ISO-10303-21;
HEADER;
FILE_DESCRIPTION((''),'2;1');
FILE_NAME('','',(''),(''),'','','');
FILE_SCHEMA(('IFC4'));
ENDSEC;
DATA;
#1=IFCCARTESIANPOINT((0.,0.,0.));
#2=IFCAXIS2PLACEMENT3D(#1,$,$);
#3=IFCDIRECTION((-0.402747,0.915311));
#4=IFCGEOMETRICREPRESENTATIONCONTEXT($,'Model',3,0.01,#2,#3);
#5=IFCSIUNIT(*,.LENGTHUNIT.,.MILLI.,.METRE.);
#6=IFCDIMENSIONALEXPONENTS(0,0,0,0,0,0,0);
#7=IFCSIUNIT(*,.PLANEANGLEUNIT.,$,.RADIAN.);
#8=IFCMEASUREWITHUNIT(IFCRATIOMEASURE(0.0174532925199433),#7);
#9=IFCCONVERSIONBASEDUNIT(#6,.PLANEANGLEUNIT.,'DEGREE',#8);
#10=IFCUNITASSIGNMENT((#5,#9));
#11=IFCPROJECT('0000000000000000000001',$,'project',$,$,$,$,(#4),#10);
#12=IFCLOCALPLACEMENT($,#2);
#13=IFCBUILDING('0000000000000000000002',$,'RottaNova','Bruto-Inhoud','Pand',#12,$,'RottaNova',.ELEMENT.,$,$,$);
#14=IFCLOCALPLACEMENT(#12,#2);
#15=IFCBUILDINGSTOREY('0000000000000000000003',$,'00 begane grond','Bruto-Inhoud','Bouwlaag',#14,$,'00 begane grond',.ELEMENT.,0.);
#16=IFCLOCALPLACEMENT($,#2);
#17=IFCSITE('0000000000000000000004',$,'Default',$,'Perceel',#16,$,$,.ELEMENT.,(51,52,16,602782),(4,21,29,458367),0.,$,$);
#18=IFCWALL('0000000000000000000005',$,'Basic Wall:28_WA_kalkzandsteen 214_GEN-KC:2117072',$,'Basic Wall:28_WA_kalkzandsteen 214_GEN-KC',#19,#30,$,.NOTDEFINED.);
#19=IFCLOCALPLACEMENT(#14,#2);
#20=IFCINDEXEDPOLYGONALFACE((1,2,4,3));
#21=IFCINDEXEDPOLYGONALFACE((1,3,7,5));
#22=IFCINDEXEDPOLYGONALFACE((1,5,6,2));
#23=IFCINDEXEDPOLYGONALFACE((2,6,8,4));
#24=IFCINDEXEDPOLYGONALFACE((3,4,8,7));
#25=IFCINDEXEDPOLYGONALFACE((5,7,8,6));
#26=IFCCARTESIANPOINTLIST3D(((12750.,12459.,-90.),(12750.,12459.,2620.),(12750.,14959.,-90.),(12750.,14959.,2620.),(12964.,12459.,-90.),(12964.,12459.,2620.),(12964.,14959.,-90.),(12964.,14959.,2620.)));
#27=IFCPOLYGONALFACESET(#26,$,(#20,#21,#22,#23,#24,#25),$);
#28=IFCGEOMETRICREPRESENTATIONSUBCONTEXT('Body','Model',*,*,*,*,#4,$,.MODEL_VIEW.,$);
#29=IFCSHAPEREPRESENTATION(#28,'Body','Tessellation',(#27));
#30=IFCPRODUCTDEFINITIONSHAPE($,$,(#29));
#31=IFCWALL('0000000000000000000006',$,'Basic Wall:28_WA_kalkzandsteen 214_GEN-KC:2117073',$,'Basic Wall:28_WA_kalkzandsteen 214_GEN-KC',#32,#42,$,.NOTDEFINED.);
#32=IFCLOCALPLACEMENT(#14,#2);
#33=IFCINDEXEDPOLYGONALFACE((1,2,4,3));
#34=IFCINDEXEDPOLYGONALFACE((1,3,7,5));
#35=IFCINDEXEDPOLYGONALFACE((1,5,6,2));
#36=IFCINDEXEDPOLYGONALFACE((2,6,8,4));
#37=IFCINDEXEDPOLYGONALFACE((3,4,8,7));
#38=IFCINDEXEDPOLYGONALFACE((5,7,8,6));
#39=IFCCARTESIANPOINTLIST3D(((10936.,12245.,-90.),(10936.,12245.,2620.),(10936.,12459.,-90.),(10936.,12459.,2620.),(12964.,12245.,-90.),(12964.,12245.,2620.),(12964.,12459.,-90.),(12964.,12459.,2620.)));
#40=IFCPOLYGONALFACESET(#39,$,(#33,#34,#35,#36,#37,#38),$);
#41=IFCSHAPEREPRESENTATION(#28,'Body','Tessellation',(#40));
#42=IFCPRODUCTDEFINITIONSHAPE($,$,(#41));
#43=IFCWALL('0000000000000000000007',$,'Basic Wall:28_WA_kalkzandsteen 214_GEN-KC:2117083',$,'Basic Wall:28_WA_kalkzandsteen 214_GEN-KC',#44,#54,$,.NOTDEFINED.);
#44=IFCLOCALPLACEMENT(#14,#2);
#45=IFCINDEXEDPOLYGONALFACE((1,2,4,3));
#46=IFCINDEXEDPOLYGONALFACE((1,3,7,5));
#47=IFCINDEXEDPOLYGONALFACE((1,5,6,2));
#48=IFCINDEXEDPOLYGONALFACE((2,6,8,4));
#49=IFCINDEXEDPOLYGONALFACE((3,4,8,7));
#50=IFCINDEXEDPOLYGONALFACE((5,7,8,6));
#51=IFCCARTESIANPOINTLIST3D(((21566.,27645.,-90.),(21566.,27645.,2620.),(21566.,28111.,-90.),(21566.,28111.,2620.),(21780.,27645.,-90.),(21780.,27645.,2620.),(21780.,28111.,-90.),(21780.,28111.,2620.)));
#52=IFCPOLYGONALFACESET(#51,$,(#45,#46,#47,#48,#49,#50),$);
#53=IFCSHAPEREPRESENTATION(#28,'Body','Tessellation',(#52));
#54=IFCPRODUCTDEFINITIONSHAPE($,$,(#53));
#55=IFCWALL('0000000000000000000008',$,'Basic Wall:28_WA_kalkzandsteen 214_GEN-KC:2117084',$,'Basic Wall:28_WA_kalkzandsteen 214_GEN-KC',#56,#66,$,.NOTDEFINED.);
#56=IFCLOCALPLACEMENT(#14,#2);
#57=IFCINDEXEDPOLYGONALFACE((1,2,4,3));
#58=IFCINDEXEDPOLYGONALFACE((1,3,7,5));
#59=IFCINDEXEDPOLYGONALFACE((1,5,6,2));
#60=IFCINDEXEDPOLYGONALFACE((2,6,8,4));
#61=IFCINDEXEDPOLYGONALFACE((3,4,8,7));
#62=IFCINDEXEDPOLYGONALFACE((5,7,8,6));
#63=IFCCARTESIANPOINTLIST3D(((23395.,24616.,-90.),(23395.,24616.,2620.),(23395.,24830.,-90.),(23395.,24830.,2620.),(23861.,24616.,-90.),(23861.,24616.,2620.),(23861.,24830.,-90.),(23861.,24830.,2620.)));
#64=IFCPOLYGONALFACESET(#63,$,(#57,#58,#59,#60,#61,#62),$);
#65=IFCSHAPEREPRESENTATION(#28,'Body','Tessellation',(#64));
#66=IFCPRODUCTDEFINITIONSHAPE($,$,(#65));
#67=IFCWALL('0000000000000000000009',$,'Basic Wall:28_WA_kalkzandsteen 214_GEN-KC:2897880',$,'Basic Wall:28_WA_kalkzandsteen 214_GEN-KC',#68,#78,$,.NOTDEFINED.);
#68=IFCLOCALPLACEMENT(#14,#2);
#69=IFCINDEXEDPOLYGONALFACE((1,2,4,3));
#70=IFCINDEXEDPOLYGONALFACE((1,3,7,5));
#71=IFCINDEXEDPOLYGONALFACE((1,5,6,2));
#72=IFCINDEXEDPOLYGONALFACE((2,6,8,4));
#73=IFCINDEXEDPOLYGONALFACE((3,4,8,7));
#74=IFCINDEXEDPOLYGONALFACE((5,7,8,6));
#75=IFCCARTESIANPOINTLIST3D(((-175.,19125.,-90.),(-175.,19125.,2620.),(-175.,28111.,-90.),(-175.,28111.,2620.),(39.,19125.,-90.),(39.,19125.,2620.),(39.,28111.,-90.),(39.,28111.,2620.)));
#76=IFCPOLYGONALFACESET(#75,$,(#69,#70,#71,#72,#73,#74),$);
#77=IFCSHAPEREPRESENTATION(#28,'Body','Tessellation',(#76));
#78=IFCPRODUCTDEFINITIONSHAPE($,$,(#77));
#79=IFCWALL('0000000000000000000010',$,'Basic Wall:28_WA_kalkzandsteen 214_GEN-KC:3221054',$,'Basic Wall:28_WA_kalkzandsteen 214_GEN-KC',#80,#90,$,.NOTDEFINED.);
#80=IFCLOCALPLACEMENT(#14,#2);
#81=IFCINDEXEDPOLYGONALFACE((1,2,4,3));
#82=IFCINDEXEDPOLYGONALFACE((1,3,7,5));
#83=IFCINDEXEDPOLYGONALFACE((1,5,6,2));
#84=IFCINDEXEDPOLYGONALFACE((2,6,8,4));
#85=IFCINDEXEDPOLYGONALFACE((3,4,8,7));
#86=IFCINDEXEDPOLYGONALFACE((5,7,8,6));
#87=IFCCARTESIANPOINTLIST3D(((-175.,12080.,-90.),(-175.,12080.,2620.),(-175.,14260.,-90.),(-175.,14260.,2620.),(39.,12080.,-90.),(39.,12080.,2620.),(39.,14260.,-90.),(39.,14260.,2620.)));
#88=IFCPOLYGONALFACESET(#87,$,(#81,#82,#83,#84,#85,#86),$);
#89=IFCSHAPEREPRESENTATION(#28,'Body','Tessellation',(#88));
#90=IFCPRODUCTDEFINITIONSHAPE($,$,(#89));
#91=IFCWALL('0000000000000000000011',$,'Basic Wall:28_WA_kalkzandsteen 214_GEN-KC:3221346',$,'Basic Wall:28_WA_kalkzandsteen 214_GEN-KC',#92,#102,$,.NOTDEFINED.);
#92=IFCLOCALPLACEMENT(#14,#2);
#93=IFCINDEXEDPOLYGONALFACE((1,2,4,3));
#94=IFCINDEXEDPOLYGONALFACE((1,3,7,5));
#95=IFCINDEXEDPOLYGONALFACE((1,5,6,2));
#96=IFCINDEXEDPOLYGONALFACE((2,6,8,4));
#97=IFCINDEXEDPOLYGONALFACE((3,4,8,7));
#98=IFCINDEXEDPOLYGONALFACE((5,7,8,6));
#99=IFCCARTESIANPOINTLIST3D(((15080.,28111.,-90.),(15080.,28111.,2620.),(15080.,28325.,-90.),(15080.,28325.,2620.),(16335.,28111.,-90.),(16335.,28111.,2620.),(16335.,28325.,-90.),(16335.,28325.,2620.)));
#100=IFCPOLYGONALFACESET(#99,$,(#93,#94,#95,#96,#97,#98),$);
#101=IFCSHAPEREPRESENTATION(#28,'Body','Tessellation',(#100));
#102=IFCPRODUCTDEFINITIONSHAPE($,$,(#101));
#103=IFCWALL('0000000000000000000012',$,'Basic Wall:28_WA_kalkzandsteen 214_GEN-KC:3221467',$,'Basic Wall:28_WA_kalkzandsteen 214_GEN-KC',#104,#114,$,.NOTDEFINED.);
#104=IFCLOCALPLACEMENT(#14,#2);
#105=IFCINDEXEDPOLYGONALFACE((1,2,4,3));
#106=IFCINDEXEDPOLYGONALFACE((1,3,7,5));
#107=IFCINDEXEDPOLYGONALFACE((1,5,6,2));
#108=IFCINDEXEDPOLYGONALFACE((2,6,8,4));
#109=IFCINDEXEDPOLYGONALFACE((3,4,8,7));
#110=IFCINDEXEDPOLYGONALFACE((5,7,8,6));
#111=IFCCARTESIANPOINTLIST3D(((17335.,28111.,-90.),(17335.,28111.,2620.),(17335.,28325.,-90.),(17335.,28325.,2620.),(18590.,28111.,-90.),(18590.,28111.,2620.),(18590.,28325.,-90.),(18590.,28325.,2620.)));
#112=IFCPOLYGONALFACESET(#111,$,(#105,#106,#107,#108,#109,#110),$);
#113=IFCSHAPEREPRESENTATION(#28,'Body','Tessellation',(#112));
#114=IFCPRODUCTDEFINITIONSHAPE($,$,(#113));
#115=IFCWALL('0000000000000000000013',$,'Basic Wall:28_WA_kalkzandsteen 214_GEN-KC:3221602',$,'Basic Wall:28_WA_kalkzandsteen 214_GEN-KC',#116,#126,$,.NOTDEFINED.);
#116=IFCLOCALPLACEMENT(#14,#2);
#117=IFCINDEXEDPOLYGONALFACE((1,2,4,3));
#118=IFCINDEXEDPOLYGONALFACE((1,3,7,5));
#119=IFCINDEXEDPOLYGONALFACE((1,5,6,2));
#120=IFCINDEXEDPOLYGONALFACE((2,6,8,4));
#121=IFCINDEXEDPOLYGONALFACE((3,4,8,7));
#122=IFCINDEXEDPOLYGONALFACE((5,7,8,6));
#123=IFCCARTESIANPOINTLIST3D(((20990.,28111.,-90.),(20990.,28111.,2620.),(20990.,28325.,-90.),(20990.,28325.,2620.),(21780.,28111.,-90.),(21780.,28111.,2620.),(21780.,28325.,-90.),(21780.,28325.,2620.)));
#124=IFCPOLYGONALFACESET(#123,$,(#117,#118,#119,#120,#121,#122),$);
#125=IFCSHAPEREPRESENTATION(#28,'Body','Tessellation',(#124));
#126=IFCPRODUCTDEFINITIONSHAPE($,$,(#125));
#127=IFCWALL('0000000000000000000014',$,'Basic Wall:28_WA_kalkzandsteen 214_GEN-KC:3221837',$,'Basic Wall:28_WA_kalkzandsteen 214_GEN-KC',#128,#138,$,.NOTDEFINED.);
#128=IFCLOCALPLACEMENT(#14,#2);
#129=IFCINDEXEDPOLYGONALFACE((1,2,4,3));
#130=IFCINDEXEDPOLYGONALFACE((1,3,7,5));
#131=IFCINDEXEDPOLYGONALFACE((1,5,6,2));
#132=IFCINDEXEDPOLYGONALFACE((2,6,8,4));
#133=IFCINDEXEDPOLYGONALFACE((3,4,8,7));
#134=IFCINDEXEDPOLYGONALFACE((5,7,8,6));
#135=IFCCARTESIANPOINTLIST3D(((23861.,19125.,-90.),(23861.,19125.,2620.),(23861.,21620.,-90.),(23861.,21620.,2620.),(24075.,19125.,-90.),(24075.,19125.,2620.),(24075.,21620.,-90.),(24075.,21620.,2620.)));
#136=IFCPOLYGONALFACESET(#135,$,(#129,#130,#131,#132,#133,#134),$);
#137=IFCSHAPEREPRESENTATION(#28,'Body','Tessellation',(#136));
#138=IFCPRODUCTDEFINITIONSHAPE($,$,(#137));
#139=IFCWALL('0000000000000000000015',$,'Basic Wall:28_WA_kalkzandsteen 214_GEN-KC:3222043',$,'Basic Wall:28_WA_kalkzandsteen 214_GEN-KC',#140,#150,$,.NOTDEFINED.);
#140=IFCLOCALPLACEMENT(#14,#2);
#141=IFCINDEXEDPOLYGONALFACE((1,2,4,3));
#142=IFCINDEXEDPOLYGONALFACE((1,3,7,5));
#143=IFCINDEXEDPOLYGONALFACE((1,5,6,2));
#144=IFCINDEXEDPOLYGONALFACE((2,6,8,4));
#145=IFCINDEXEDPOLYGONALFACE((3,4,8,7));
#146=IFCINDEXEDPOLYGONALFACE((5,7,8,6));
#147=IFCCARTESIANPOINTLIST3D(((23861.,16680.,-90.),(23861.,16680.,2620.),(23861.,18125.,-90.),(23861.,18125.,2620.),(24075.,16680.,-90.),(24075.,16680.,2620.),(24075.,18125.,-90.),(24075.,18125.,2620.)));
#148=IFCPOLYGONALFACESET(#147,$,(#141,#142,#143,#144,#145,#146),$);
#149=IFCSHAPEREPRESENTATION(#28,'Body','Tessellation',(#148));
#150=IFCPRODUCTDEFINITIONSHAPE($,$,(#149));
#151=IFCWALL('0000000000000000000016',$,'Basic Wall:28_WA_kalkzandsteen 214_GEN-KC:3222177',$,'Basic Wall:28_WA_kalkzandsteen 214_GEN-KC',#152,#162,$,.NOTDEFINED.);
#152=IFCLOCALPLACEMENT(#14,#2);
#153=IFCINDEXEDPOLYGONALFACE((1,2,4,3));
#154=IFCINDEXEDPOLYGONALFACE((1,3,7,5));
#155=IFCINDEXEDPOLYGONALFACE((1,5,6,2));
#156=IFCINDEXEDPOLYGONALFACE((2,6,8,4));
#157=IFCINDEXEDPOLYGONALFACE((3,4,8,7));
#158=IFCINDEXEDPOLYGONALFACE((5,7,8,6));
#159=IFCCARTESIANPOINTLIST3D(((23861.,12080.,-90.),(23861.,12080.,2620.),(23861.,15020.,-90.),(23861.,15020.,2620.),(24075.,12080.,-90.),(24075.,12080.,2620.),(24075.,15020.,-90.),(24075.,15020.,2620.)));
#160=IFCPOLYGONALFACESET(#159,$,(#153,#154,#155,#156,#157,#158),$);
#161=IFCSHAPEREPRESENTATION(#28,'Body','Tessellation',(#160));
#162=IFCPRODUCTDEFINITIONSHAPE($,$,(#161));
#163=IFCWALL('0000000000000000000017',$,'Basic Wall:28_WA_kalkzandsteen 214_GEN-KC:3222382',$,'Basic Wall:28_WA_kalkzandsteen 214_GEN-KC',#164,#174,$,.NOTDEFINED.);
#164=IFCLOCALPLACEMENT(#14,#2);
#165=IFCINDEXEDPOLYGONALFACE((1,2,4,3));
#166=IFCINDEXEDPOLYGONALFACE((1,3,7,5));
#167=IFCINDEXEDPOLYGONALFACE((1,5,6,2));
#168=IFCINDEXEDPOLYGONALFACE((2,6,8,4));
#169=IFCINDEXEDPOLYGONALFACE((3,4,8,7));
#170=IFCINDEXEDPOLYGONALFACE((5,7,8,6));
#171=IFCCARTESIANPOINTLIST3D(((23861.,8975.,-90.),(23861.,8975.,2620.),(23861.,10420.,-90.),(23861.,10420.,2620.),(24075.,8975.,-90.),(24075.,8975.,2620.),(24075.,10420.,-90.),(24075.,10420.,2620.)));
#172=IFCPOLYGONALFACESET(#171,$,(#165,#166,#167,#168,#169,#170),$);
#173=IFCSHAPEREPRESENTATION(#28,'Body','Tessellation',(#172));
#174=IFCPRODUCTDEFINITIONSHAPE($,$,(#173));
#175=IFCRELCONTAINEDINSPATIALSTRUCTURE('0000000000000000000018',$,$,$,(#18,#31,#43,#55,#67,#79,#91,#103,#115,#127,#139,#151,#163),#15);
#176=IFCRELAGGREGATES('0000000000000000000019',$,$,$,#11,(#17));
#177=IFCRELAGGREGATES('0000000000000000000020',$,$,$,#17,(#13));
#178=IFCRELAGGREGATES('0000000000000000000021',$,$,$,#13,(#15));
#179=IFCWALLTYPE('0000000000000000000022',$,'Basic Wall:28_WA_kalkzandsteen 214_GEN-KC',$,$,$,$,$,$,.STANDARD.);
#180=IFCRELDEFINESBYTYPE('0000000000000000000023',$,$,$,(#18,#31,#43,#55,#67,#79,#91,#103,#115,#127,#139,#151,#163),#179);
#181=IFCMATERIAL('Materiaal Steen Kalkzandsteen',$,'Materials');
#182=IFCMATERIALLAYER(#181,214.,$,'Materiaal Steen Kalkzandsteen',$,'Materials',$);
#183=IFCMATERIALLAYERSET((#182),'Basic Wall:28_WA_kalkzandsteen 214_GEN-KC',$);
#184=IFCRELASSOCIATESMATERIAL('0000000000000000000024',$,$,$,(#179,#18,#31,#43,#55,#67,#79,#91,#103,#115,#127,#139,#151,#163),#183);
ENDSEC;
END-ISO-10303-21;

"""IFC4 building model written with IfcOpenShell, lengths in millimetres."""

from ifc_helpers import new_model, entity, si_unit, converted_unit, direction, frame, frame_2d, origin, place, context, subcontext, project, spatial, rectangle, extrude, material, layer, layer_set, type_object, element, save


model = new_model("IFC4")

# Units and contexts
model_context = context("Model", 3, precision=0.01, world=origin(), true_north=direction((-0.402747, 0.915311)))
body_context = subcontext(model_context, "Body", "Model", "MODEL_VIEW")
ifc_project = project(units=[si_unit("LENGTHUNIT", "METRE", prefix="MILLI"), converted_unit("PLANEANGLEUNIT", "DEGREE", entity("IfcRatioMeasure", 0.0174532925199433), si_unit("PLANEANGLEUNIT", "RADIAN"), dimensions=[0, 0, 0, 0, 0, 0, 0])], contexts=[model_context])

# Site, building, storey
site_placement = place(None, origin())
site = spatial("IfcSite", under=ifc_project, at=site_placement, Name="Default", ObjectType="Perceel", CompositionType="ELEMENT", RefLatitude=(51, 52, 16, 602782), RefLongitude=(4, 21, 29, 458367), RefElevation=0.0)
building_placement = place(None, origin())
building = spatial("IfcBuilding", under=site, at=building_placement, Name="RottaNova", Description="Bruto-Inhoud", ObjectType="Pand", LongName="RottaNova", CompositionType="ELEMENT")
storey_placement = place(building_placement, origin())
storey = spatial("IfcBuildingStorey", under=building, at=storey_placement, Name="00 begane grond", Description="Bruto-Inhoud", ObjectType="Bouwlaag", LongName="00 begane grond", CompositionType="ELEMENT", Elevation=0.0)

# Walls
ifc_material_1 = material(Name="Materiaal Steen Kalkzandsteen", Category="Materials")
ifc_layer_1 = layer(ifc_material_1, 214.0, Name="Materiaal Steen Kalkzandsteen", Category="Materials")
ifc_layer_set_1 = layer_set([ifc_layer_1], Name="Basic Wall:28_WA_kalkzandsteen 214_GEN-KC")
wall_type_1 = type_object("IfcWallType", Name="Basic Wall:28_WA_kalkzandsteen 214_GEN-KC", PredefinedType="STANDARD", material=ifc_layer_set_1)
wall_1_placement = place(storey_placement, frame((12857.0, 12459.0, -90.0), z_axis=(0.0, 0.0, 1.0), x_axis=(0.0, 1.0, 0.0)))
element("IfcWall", 1, at=wall_1_placement, inside=storey, type_object=wall_type_1, material=ifc_layer_set_1, Name="Basic Wall:28_WA_kalkzandsteen 214_GEN-KC:2117072", ObjectType="Basic Wall:28_WA_kalkzandsteen 214_GEN-KC", PredefinedType="NOTDEFINED", context=body_context, shape_type="SweptSolid", body=[
    extrude(rectangle(XDim=2500.0, YDim=214.0, at=frame_2d((1250.0, 0.0), x_axis=(-1.0, 0.0))), origin(), (0.0, 0.0, 1.0), 2710.0),
])
wall_2_placement = place(storey_placement, frame((10936.0, 12352.0, -90.0)))
element("IfcWall", 2, at=wall_2_placement, inside=storey, type_object=wall_type_1, material=ifc_layer_set_1, Name="Basic Wall:28_WA_kalkzandsteen 214_GEN-KC:2117073", ObjectType="Basic Wall:28_WA_kalkzandsteen 214_GEN-KC", PredefinedType="NOTDEFINED", context=body_context, shape_type="SweptSolid", body=[
    extrude(rectangle(XDim=2028.0, YDim=214.0, at=frame_2d((1014.0, 0.0), x_axis=(-1.0, 0.0))), origin(), (0.0, 0.0, 1.0), 2710.0),
])
wall_3_placement = place(storey_placement, frame((21673.0, 28111.0, -90.0), z_axis=(0.0, 0.0, 1.0), x_axis=(0.0, -1.0, 0.0)))
element("IfcWall", 3, at=wall_3_placement, inside=storey, type_object=wall_type_1, material=ifc_layer_set_1, Name="Basic Wall:28_WA_kalkzandsteen 214_GEN-KC:2117083", ObjectType="Basic Wall:28_WA_kalkzandsteen 214_GEN-KC", PredefinedType="NOTDEFINED", context=body_context, shape_type="SweptSolid", body=[
    extrude(rectangle(XDim=466.0, YDim=214.0, at=frame_2d((233.0, 0.0), x_axis=(-1.0, 0.0))), origin(), (0.0, 0.0, 1.0), 2710.0),
])
wall_4_placement = place(storey_placement, frame((23395.0, 24723.0, -90.0)))
element("IfcWall", 4, at=wall_4_placement, inside=storey, type_object=wall_type_1, material=ifc_layer_set_1, Name="Basic Wall:28_WA_kalkzandsteen 214_GEN-KC:2117084", ObjectType="Basic Wall:28_WA_kalkzandsteen 214_GEN-KC", PredefinedType="NOTDEFINED", context=body_context, shape_type="SweptSolid", body=[
    extrude(rectangle(XDim=466.0, YDim=214.0, at=frame_2d((233.0, 0.0), x_axis=(-1.0, 0.0))), origin(), (0.0, 0.0, 1.0), 2710.0),
])
wall_5_placement = place(storey_placement, frame((-68.0, 19125.0, -90.0), z_axis=(0.0, 0.0, 1.0), x_axis=(0.0, 1.0, 0.0)))
element("IfcWall", 5, at=wall_5_placement, inside=storey, type_object=wall_type_1, material=ifc_layer_set_1, Name="Basic Wall:28_WA_kalkzandsteen 214_GEN-KC:2897880", ObjectType="Basic Wall:28_WA_kalkzandsteen 214_GEN-KC", PredefinedType="NOTDEFINED", context=body_context, shape_type="SweptSolid", body=[
    extrude(rectangle(XDim=8986.0, YDim=214.0, at=frame_2d((4493.0, 0.0), x_axis=(-1.0, 0.0))), origin(), (0.0, 0.0, 1.0), 2710.0),
])
wall_6_placement = place(storey_placement, frame((-68.0, 12080.0, -90.0), z_axis=(0.0, 0.0, 1.0), x_axis=(0.0, 1.0, 0.0)))
element("IfcWall", 6, at=wall_6_placement, inside=storey, type_object=wall_type_1, material=ifc_layer_set_1, Name="Basic Wall:28_WA_kalkzandsteen 214_GEN-KC:3221054", ObjectType="Basic Wall:28_WA_kalkzandsteen 214_GEN-KC", PredefinedType="NOTDEFINED", context=body_context, shape_type="SweptSolid", body=[
    extrude(rectangle(XDim=2180.0, YDim=214.0, at=frame_2d((1090.0, 0.0), x_axis=(-1.0, 0.0))), origin(), (0.0, 0.0, 1.0), 2710.0),
])
wall_7_placement = place(storey_placement, frame((15080.0, 28218.0, -90.0)))
element("IfcWall", 7, at=wall_7_placement, inside=storey, type_object=wall_type_1, material=ifc_layer_set_1, Name="Basic Wall:28_WA_kalkzandsteen 214_GEN-KC:3221346", ObjectType="Basic Wall:28_WA_kalkzandsteen 214_GEN-KC", PredefinedType="NOTDEFINED", context=body_context, shape_type="SweptSolid", body=[
    extrude(rectangle(XDim=1255.0, YDim=214.0, at=frame_2d((627.5, 0.0), x_axis=(-1.0, 0.0))), origin(), (0.0, 0.0, 1.0), 2710.0),
])
wall_8_placement = place(storey_placement, frame((17335.0, 28218.0, -90.0)))
element("IfcWall", 8, at=wall_8_placement, inside=storey, type_object=wall_type_1, material=ifc_layer_set_1, Name="Basic Wall:28_WA_kalkzandsteen 214_GEN-KC:3221467", ObjectType="Basic Wall:28_WA_kalkzandsteen 214_GEN-KC", PredefinedType="NOTDEFINED", context=body_context, shape_type="SweptSolid", body=[
    extrude(rectangle(XDim=1255.0, YDim=214.0, at=frame_2d((627.5, 0.0), x_axis=(-1.0, 0.0))), origin(), (0.0, 0.0, 1.0), 2710.0),
])
wall_9_placement = place(storey_placement, frame((20990.0, 28218.0, -90.0)))
element("IfcWall", 9, at=wall_9_placement, inside=storey, type_object=wall_type_1, material=ifc_layer_set_1, Name="Basic Wall:28_WA_kalkzandsteen 214_GEN-KC:3221602", ObjectType="Basic Wall:28_WA_kalkzandsteen 214_GEN-KC", PredefinedType="NOTDEFINED", context=body_context, shape_type="SweptSolid", body=[
    extrude(rectangle(XDim=790.0, YDim=214.0, at=frame_2d((395.0, 0.0), x_axis=(-1.0, 0.0))), origin(), (0.0, 0.0, 1.0), 2710.0),
])
wall_10_placement = place(storey_placement, frame((23968.0, 21620.0, -90.0), z_axis=(0.0, 0.0, 1.0), x_axis=(0.0, -1.0, 0.0)))
element("IfcWall", 10, at=wall_10_placement, inside=storey, type_object=wall_type_1, material=ifc_layer_set_1, Name="Basic Wall:28_WA_kalkzandsteen 214_GEN-KC:3221837", ObjectType="Basic Wall:28_WA_kalkzandsteen 214_GEN-KC", PredefinedType="NOTDEFINED", context=body_context, shape_type="SweptSolid", body=[
    extrude(rectangle(XDim=2495.0, YDim=214.0, at=frame_2d((1247.5, 0.0), x_axis=(-1.0, 0.0))), origin(), (0.0, 0.0, 1.0), 2710.0),
])
wall_11_placement = place(storey_placement, frame((23968.0, 18125.0, -90.0), z_axis=(0.0, 0.0, 1.0), x_axis=(0.0, -1.0, 0.0)))
element("IfcWall", 11, at=wall_11_placement, inside=storey, type_object=wall_type_1, material=ifc_layer_set_1, Name="Basic Wall:28_WA_kalkzandsteen 214_GEN-KC:3222043", ObjectType="Basic Wall:28_WA_kalkzandsteen 214_GEN-KC", PredefinedType="NOTDEFINED", context=body_context, shape_type="SweptSolid", body=[
    extrude(rectangle(XDim=1445.0, YDim=214.0, at=frame_2d((722.5, 0.0), x_axis=(-1.0, 0.0))), origin(), (0.0, 0.0, 1.0), 2710.0),
])
wall_12_placement = place(storey_placement, frame((23968.0, 15020.0, -90.0), z_axis=(0.0, 0.0, 1.0), x_axis=(0.0, -1.0, 0.0)))
element("IfcWall", 12, at=wall_12_placement, inside=storey, type_object=wall_type_1, material=ifc_layer_set_1, Name="Basic Wall:28_WA_kalkzandsteen 214_GEN-KC:3222177", ObjectType="Basic Wall:28_WA_kalkzandsteen 214_GEN-KC", PredefinedType="NOTDEFINED", context=body_context, shape_type="SweptSolid", body=[
    extrude(rectangle(XDim=2940.0, YDim=214.0, at=frame_2d((1470.0, 0.0), x_axis=(-1.0, 0.0))), origin(), (0.0, 0.0, 1.0), 2710.0),
])
wall_13_placement = place(storey_placement, frame((23968.0, 10420.0, -90.0), z_axis=(0.0, 0.0, 1.0), x_axis=(0.0, -1.0, 0.0)))
element("IfcWall", 13, at=wall_13_placement, inside=storey, type_object=wall_type_1, material=ifc_layer_set_1, Name="Basic Wall:28_WA_kalkzandsteen 214_GEN-KC:3222382", ObjectType="Basic Wall:28_WA_kalkzandsteen 214_GEN-KC", PredefinedType="NOTDEFINED", context=body_context, shape_type="SweptSolid", body=[
    extrude(rectangle(XDim=1445.0, YDim=214.0, at=frame_2d((722.5, 0.0), x_axis=(-1.0, 0.0))), origin(), (0.0, 0.0, 1.0), 2710.0),
])

save(model, "model.ifc")
